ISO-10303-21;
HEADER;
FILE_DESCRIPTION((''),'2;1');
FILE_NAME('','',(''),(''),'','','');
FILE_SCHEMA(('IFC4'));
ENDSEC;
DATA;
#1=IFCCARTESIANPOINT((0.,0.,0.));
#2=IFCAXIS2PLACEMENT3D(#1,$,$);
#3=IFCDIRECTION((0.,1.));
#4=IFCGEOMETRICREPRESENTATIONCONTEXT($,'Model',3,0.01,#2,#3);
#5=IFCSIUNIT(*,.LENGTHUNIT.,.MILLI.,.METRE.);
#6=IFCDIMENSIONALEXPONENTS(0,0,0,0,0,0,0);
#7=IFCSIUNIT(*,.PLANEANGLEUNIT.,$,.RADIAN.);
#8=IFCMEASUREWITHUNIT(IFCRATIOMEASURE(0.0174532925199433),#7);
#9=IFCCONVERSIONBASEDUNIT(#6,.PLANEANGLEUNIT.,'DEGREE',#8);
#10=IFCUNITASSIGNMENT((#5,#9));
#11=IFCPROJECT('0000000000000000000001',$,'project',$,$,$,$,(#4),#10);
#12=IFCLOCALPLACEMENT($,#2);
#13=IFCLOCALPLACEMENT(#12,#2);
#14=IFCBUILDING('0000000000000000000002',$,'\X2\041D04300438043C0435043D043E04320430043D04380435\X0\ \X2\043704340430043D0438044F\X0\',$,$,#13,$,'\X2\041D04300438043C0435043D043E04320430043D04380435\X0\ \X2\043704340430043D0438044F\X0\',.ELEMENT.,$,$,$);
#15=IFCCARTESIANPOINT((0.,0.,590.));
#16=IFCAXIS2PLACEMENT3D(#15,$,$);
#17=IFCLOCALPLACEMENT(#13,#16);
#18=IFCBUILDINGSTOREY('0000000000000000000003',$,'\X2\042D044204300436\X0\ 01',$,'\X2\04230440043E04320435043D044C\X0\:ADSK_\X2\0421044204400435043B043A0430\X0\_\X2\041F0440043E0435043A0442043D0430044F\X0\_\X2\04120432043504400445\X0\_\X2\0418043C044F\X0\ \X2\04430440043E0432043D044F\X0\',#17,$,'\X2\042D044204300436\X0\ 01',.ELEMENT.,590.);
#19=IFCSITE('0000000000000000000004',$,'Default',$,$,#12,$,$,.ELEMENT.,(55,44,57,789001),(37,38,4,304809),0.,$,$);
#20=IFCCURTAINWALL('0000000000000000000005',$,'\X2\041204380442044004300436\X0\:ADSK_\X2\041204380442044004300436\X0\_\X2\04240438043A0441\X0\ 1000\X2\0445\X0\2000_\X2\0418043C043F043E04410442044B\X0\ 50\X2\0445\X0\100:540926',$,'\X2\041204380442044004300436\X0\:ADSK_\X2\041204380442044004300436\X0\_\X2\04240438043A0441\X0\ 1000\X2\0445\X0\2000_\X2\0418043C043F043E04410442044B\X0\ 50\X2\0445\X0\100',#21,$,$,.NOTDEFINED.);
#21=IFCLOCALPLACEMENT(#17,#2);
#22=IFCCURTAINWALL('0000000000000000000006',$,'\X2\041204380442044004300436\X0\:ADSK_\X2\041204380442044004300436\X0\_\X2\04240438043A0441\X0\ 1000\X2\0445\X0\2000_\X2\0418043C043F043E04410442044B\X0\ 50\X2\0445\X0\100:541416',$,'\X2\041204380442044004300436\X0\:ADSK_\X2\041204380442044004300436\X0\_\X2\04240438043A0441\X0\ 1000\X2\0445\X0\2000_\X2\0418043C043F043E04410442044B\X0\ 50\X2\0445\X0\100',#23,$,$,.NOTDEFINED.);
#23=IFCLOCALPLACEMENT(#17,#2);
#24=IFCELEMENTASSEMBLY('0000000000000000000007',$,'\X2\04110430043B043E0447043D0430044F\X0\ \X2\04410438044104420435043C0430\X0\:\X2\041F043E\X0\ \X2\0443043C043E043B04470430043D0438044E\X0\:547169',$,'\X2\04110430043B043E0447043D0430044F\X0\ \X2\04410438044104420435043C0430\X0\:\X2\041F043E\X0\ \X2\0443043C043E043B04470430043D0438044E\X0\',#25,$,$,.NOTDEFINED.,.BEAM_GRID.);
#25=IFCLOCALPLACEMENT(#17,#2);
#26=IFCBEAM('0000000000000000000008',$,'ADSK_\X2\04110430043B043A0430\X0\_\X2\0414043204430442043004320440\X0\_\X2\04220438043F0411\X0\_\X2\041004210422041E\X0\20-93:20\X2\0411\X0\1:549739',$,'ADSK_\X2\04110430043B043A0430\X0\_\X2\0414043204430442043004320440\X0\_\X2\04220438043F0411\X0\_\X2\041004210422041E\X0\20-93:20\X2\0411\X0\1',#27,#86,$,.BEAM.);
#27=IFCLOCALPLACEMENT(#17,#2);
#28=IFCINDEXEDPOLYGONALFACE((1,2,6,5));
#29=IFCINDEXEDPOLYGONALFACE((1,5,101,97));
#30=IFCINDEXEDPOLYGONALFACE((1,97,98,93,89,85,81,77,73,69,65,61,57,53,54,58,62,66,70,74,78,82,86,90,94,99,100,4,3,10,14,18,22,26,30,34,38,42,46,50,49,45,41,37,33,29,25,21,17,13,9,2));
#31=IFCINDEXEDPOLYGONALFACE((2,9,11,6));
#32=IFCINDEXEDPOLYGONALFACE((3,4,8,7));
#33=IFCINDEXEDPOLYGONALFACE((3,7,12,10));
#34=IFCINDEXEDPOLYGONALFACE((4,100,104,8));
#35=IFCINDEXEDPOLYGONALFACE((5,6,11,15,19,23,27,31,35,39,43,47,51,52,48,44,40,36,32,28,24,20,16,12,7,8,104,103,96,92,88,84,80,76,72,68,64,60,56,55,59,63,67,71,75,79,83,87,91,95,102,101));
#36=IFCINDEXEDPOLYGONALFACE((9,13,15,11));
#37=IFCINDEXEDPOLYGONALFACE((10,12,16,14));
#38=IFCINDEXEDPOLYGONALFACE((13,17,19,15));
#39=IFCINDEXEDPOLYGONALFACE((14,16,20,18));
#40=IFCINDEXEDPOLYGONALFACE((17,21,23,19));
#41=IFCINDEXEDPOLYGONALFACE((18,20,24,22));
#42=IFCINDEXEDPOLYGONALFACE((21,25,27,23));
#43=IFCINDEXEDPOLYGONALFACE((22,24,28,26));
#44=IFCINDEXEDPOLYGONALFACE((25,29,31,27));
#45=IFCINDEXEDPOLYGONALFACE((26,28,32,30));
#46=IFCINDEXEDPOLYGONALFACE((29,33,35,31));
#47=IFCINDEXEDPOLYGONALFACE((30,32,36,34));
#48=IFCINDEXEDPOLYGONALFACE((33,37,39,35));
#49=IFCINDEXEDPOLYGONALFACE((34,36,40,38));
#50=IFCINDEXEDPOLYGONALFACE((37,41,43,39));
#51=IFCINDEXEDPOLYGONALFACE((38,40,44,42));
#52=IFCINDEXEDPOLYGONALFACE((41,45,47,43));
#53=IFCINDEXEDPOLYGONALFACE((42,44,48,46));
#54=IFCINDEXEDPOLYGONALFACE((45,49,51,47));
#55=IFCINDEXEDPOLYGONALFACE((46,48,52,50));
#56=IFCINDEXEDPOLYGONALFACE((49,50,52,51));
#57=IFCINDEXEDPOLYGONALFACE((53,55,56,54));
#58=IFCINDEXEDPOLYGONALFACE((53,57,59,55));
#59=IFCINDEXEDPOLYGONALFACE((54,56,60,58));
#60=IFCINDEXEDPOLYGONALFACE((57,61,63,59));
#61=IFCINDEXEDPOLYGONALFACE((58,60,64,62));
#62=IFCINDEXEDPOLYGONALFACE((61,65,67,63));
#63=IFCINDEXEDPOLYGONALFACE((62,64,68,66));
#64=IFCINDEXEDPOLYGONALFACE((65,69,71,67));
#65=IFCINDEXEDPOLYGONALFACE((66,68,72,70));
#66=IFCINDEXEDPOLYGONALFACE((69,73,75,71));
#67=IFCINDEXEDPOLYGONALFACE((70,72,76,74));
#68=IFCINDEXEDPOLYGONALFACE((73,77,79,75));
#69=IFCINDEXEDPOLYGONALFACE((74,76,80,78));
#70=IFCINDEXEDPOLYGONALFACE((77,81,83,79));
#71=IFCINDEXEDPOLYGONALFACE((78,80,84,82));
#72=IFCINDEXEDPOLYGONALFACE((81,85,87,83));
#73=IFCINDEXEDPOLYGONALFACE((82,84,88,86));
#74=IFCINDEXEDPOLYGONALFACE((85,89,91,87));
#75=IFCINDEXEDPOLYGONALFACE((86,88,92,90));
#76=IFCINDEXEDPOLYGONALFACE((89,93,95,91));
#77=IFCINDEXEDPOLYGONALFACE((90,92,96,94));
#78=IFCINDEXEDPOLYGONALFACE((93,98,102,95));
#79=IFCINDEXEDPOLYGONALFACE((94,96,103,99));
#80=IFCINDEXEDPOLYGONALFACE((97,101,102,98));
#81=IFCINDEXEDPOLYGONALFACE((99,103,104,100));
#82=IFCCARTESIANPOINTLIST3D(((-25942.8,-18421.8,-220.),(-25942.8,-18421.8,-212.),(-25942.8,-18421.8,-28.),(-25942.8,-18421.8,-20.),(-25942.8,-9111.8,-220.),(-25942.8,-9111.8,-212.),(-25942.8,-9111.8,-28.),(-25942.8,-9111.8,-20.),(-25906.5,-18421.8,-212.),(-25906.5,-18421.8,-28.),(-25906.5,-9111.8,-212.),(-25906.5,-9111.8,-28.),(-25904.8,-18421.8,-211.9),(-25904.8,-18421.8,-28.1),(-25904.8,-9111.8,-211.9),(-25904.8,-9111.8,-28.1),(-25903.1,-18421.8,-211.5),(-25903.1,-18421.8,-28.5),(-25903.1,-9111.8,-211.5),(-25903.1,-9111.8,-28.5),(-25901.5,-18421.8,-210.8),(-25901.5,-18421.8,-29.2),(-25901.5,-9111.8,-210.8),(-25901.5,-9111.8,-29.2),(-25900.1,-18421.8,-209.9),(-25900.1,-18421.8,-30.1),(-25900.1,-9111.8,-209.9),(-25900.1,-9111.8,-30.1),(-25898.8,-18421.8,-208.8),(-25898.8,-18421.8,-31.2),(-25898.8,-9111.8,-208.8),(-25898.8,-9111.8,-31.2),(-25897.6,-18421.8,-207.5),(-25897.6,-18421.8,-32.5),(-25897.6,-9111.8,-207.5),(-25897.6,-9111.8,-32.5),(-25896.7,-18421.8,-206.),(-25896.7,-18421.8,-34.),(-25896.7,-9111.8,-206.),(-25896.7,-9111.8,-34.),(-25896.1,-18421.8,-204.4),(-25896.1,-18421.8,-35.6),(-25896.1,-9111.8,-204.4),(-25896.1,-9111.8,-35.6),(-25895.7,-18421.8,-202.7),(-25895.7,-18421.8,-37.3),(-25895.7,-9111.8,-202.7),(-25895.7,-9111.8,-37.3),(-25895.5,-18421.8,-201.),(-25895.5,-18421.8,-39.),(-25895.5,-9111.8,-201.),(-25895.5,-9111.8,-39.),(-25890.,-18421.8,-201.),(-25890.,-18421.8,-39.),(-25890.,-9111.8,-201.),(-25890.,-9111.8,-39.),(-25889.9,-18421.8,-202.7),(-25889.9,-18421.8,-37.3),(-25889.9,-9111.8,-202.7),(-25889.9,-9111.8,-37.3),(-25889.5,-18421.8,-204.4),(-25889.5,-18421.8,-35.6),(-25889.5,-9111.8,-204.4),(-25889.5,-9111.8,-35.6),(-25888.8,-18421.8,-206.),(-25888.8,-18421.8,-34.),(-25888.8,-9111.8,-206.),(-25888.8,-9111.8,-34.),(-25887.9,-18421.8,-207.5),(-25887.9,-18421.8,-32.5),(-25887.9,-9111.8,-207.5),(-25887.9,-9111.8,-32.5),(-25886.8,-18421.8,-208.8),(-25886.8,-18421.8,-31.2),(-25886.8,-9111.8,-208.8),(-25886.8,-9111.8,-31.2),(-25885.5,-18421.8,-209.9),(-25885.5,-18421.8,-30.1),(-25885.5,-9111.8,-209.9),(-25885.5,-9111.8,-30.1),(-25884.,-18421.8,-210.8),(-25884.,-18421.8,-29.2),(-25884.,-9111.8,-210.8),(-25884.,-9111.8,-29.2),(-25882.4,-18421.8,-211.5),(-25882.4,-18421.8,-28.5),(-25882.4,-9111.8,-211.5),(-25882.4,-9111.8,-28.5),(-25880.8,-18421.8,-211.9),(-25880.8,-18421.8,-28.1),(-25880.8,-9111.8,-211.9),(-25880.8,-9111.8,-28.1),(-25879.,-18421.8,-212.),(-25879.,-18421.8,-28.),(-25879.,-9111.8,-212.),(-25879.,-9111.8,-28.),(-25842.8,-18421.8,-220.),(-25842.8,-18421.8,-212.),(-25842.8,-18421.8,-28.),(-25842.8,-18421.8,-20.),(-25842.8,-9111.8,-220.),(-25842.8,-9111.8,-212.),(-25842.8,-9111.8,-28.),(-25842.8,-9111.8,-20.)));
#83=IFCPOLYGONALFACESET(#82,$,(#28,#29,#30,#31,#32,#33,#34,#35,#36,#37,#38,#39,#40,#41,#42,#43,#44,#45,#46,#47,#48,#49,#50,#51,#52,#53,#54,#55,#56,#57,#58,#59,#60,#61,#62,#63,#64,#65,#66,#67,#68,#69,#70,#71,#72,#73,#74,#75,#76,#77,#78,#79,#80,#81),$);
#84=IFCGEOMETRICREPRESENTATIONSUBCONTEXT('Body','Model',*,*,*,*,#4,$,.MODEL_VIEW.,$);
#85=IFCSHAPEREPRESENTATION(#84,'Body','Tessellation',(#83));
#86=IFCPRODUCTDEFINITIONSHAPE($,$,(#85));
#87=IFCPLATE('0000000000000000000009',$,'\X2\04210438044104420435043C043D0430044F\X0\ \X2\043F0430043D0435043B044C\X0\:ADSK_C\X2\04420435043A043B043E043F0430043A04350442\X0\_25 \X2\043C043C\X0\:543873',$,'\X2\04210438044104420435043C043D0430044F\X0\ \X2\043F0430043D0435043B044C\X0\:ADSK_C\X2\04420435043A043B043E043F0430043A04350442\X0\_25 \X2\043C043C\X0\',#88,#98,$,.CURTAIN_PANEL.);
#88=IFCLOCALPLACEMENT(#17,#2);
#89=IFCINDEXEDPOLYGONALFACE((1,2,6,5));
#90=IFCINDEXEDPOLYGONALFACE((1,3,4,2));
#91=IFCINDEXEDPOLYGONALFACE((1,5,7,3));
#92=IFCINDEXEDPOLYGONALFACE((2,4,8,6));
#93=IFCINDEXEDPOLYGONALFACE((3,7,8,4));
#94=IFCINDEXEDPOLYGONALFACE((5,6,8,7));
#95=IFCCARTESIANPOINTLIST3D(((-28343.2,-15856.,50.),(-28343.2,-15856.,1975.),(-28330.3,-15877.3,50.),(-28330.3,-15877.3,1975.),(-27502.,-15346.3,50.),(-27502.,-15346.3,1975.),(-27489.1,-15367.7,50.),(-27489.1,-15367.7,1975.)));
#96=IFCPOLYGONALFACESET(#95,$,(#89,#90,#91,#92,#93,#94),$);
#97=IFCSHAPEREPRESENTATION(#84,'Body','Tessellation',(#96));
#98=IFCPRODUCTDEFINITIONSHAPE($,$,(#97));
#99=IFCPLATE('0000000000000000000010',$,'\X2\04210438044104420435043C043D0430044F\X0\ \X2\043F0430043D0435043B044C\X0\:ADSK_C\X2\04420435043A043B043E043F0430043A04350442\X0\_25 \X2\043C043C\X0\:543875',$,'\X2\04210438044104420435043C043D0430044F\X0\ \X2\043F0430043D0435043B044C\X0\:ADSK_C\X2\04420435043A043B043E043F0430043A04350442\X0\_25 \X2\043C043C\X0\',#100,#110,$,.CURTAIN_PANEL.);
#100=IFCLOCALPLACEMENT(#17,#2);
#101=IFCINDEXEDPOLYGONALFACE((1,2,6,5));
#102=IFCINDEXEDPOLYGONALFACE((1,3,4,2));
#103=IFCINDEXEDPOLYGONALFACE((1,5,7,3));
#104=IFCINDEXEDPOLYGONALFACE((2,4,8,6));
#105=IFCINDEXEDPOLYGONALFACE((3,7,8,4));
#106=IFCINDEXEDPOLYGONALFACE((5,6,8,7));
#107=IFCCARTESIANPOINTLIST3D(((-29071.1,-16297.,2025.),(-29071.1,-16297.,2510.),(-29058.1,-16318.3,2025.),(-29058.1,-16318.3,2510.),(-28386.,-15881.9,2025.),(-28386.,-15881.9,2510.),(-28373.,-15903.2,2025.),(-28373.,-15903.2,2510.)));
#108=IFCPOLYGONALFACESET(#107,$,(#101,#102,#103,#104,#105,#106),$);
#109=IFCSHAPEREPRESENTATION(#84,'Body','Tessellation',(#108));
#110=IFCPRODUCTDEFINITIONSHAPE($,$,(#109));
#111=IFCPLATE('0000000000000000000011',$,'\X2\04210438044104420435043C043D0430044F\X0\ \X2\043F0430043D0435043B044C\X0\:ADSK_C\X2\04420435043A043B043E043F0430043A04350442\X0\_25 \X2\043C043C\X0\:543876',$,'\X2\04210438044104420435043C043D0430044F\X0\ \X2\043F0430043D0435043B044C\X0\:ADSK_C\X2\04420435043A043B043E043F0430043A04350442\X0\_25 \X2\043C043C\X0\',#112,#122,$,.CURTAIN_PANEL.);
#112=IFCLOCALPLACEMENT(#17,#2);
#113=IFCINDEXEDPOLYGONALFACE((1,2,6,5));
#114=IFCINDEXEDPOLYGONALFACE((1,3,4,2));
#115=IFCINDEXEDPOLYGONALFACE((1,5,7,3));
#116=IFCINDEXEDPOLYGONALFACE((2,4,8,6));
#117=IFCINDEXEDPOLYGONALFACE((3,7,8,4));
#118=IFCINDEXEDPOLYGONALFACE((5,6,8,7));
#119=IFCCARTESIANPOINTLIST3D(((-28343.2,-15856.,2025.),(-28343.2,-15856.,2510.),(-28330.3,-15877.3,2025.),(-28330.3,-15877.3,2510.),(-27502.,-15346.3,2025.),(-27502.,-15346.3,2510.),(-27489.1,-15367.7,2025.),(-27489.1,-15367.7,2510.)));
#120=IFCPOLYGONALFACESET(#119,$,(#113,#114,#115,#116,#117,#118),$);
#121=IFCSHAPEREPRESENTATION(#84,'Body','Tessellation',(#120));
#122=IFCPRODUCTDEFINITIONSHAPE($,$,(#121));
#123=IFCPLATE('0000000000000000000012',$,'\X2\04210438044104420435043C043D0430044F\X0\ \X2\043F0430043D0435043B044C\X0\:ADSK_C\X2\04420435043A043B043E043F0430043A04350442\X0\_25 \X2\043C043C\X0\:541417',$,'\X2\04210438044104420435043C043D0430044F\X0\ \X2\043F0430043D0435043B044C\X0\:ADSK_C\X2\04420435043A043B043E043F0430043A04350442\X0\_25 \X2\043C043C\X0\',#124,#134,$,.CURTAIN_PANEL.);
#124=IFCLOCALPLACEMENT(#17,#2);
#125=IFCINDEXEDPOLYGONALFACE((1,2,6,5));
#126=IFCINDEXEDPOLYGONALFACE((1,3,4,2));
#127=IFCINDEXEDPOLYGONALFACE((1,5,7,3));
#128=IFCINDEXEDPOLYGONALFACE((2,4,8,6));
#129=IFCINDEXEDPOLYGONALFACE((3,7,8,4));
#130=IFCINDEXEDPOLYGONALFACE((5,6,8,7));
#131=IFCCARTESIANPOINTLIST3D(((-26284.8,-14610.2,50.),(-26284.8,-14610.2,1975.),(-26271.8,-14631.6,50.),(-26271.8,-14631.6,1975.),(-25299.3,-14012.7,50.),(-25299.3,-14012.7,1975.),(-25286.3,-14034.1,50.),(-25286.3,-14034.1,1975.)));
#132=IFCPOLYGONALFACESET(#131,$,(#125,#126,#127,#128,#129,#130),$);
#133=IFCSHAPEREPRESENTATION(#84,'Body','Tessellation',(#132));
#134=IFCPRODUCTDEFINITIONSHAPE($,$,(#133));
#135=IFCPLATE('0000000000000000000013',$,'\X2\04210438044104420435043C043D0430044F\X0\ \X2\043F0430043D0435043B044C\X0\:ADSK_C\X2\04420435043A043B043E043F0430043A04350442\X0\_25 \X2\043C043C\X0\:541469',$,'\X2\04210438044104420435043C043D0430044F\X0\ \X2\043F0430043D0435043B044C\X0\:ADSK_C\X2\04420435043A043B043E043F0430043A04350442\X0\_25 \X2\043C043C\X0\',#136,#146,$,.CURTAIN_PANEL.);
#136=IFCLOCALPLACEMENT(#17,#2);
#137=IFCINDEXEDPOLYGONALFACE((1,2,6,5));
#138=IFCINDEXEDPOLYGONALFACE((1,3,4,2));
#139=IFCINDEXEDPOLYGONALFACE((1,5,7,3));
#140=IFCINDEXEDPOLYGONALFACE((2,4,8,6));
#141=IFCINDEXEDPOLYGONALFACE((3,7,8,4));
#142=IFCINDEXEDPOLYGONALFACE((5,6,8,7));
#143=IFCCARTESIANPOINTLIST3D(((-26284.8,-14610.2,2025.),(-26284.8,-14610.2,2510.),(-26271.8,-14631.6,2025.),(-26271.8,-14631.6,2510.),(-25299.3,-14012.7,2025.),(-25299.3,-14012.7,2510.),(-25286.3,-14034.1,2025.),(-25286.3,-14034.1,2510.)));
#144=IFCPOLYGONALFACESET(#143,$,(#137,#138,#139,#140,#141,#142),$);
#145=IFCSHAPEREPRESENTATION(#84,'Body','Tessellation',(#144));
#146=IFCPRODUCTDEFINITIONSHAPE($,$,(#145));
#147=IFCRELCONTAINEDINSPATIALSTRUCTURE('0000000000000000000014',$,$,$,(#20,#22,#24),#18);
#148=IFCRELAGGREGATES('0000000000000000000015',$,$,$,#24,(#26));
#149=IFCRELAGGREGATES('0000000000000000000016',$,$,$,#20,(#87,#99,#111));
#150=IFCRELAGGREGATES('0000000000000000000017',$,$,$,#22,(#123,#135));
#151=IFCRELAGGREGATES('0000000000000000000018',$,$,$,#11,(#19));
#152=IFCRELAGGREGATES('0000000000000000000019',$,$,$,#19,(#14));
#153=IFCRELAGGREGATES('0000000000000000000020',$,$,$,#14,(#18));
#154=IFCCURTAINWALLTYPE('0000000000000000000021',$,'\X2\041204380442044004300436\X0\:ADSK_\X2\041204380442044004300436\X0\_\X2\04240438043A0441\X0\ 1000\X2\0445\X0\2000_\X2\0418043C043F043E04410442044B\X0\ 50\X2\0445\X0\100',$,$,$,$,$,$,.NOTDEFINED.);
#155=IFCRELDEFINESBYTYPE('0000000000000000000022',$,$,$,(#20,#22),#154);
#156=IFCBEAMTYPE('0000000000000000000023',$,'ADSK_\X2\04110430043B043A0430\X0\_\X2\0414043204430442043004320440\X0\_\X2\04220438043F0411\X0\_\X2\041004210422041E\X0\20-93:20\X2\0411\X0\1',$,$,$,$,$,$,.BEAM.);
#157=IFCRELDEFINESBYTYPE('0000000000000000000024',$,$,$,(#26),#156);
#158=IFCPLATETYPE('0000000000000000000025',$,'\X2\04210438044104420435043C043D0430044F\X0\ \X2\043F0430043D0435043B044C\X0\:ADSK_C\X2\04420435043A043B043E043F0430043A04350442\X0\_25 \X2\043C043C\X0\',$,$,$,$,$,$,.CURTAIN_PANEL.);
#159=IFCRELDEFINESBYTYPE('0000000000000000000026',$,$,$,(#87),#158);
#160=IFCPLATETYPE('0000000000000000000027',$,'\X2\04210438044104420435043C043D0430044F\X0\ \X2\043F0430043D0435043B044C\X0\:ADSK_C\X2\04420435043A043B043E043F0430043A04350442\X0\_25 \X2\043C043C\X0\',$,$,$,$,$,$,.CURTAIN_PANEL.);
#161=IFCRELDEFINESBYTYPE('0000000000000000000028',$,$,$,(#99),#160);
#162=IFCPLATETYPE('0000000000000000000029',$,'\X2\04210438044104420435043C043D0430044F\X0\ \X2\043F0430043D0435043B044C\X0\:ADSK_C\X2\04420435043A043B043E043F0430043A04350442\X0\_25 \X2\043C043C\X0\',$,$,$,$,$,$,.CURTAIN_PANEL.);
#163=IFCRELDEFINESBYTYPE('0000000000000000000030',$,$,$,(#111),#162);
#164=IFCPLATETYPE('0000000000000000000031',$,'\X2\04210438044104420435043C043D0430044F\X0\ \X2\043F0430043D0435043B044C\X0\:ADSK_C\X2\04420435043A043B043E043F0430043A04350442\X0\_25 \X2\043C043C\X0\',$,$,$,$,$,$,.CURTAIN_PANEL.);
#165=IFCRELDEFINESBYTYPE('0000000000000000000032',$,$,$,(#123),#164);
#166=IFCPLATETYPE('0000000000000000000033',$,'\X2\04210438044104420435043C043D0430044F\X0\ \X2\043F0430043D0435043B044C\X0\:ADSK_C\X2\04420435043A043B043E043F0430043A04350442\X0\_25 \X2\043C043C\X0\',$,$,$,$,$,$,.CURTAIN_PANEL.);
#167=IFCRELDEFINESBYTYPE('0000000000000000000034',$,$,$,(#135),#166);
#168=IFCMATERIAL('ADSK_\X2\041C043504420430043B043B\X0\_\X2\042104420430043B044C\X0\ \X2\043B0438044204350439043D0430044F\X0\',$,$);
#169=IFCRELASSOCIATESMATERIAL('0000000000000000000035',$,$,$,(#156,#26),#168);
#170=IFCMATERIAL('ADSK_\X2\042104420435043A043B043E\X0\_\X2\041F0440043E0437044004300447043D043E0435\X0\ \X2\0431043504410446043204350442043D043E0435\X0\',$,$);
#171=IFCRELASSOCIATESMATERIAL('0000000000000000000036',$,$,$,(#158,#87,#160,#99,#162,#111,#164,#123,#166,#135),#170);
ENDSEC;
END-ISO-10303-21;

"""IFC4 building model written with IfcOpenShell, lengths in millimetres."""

from ifc_helpers import new_model, entity, si_unit, converted_unit, direction, frame, origin, place, context, subcontext, project, spatial, indexed_curve, outline, extrude, source, transform, mapped, material, type_object, type_shapes, element, aggregate, save


model = new_model("IFC4")

# Units and contexts
model_context = context("Model", 3, precision=0.01, world=origin(), true_north=direction((0.0, 1.0)))
body_context = subcontext(model_context, "Body", "Model", "MODEL_VIEW")
ifc_project = project(units=[si_unit("LENGTHUNIT", "METRE", prefix="MILLI"), converted_unit("PLANEANGLEUNIT", "DEGREE", entity("IfcRatioMeasure", 0.0174532925199433), si_unit("PLANEANGLEUNIT", "RADIAN"), dimensions=[0, 0, 0, 0, 0, 0, 0])], contexts=[model_context])

# Site, building, storey
site_placement = place(None, origin())
site = spatial("IfcSite", under=ifc_project, at=site_placement, Name="Default", CompositionType="ELEMENT", RefLatitude=(55, 44, 57, 789001), RefLongitude=(37, 38, 4, 304809), RefElevation=0.0)
building_placement = place(site_placement, origin())
building = spatial("IfcBuilding", under=site, at=building_placement, Name="Наименование здания", LongName="Наименование здания", CompositionType="ELEMENT")
storey_placement = place(building_placement, frame((0.0, 0.0, 590.0)))
storey = spatial("IfcBuildingStorey", under=building, at=storey_placement, Name="Этаж 01", ObjectType="Уровень:ADSK_Стрелка_Проектная_Вверх_Имя уровня", LongName="Этаж 01", CompositionType="ELEMENT", Elevation=590.0)

# Curtain walls
curtain_wall_type = type_object("IfcCurtainWallType", Name="Витраж:ADSK_Витраж_Фикс 1000х2000_Импосты 50х100", PredefinedType="NOTDEFINED")
curtain_wall_1_placement = place(storey_placement, frame((0.0, 0.0, -590.0)))
curtain_wall_1 = element("IfcCurtainWall", 1, at=curtain_wall_1_placement, inside=storey, type_object=curtain_wall_type, Name="Витраж:ADSK_Витраж_Фикс 1000х2000_Импосты 50х100:540926", ObjectType="Витраж:ADSK_Витраж_Фикс 1000х2000_Импосты 50х100", PredefinedType="NOTDEFINED")
curtain_wall_2_placement = place(storey_placement, frame((0.0, 0.0, -590.0)))
curtain_wall_2 = element("IfcCurtainWall", 2, at=curtain_wall_2_placement, inside=storey, type_object=curtain_wall_type, Name="Витраж:ADSK_Витраж_Фикс 1000х2000_Импосты 50х100:541416", ObjectType="Витраж:ADSK_Витраж_Фикс 1000х2000_Импосты 50х100", PredefinedType="NOTDEFINED")

# Element assembly, beam
assembly_placement = place(storey_placement, origin())
assembly = element("IfcElementAssembly", 3, at=assembly_placement, inside=storey, Name="Балочная система:По умолчанию:547169", ObjectType="Балочная система:По умолчанию", AssemblyPlace="NOTDEFINED", PredefinedType="BEAM_GRID")
ifc_material_1 = material(Name="ADSK_Металл_Сталь литейная")
beam_type_1 = type_object("IfcBeamType", Name="ADSK_Балка_Двутавр_ТипБ_АСТО20-93:20Б1", PredefinedType="BEAM", material=ifc_material_1)
shared_shape_1 = source(origin(), body_context, "Body", "SweptSolid", [
    extrude(outline(indexed_curve([(-100.0, -50.0), (-92.0, -50.0), (-92.0, -13.8), (-91.9, -12.0), (-91.5, -10.4), (-90.8, -8.8), (-89.9, -7.3), (-88.8, -6.0), (-87.5, -4.9), (-86.0, -3.9), (-84.4, -3.3), (-82.7, -2.9), (-81.0, -2.8), (81.0, -2.8), (82.7, -2.9), (84.4, -3.3), (86.0, -3.9), (87.5, -4.9), (88.8, -6.0), (89.9, -7.3), (90.8, -8.8), (91.5, -10.4), (91.9, -12.0), (92.0, -13.7), (92.0, -50.0), (100.0, -50.0), (100.0, 50.0), (92.0, 50.0), (92.0, 13.8), (91.9, 12.0), (91.5, 10.4), (90.8, 8.8), (89.9, 7.3), (88.8, 6.0), (87.5, 4.9), (86.0, 3.9), (84.4, 3.3), (82.7, 2.9), (81.0, 2.8), (-81.0, 2.8), (-82.7, 2.9), (-84.4, 3.3), (-86.0, 3.9), (-87.5, 4.9), (-88.8, 6.0), (-89.9, 7.3), (-90.8, 8.8), (-91.5, 10.4), (-91.9, 12.0), (-92.0, 13.8), (-92.0, 50.0), (-100.0, 50.0), (-100.0, -50.0)], self_intersect=False)), frame((-4655.0, 0.0, -100.0), z_axis=(1.0, 0.0, 0.0), x_axis=(0.0, 0.0, -1.0)), (0.0, 0.0, 1.0), 9310.0),
])
type_shapes(beam_type_1, [shared_shape_1])
beam_1_placement = place(assembly_placement, frame((-25892.8, -13766.8, -20.0), z_axis=(0.0, 0.0, 1.0), x_axis=(0.0, 1.0, 0.0)))
beam_1 = element("IfcBeam", 4, at=beam_1_placement, type_object=beam_type_1, material=ifc_material_1, Name="ADSK_Балка_Двутавр_ТипБ_АСТО20-93:20Б1:549739", ObjectType="ADSK_Балка_Двутавр_ТипБ_АСТО20-93:20Б1", PredefinedType="BEAM", context=body_context, shape_type="MappedRepresentation", body=[
    mapped(shared_shape_1, transform((0.0, 0.0, 0.0), scale=1.0)),
])
aggregate(assembly, [beam_1])

# Plates
ifc_material_2 = material(Name="ADSK_Стекло_Прозрачное бесцветное")
plate_type_1 = type_object("IfcPlateType", Name="Системная панель:ADSK_Cтеклопакет_25 мм", PredefinedType="CURTAIN_PANEL", material=ifc_material_2)
shared_shape_2 = source(origin(), body_context, "Body", "SweptSolid", [
    extrude(outline(indexed_curve([(-12.5, -491.8), (12.5, -491.8), (12.5, 491.8), (-12.5, 491.8), (-12.5, -491.8)], self_intersect=False)), frame((0.0, 0.0, 0.0), z_axis=(0.0, 0.0, 1.0), x_axis=(0.0, 1.0, 0.0)), (0.0, 0.0, 1.0), 1925.0),
])
type_shapes(plate_type_1, [shared_shape_2])
plate_1_placement = place(curtain_wall_1_placement, frame((-27916.1, -15611.8, 640.0), z_axis=(0.0, 0.0, 1.0), x_axis=(0.855267, 0.518188, 0.0)))
plate_1 = element("IfcPlate", 5, at=plate_1_placement, type_object=plate_type_1, material=ifc_material_2, Name="Системная панель:ADSK_Cтеклопакет_25 мм:543873", ObjectType="Системная панель:ADSK_Cтеклопакет_25 мм", PredefinedType="CURTAIN_PANEL", context=body_context, shape_type="MappedRepresentation", body=[
    mapped(shared_shape_2, transform((0.0, 0.0, 0.0), scale=1.0)),
])
plate_type_2 = type_object("IfcPlateType", Name="Системная панель:ADSK_Cтеклопакет_25 мм", PredefinedType="CURTAIN_PANEL", material=ifc_material_2)
shared_shape_3 = source(origin(), body_context, "Body", "SweptSolid", [
    extrude(outline(indexed_curve([(-12.5, -400.5), (12.5, -400.5), (12.5, 400.5), (-12.5, 400.5), (-12.5, -400.5)], self_intersect=False)), frame((0.0, 0.0, 0.0), z_axis=(0.0, 0.0, 1.0), x_axis=(0.0, 1.0, 0.0)), (0.0, 0.0, 1.0), 485.0),
])
type_shapes(plate_type_2, [shared_shape_3])
plate_2_placement = place(curtain_wall_1_placement, frame((-28722.0, -16100.1, 2615.0), z_axis=(0.0, 0.0, 1.0), x_axis=(0.855267, 0.518188, 0.0)))
plate_2 = element("IfcPlate", 6, at=plate_2_placement, type_object=plate_type_2, material=ifc_material_2, Name="Системная панель:ADSK_Cтеклопакет_25 мм:543875", ObjectType="Системная панель:ADSK_Cтеклопакет_25 мм", PredefinedType="CURTAIN_PANEL", context=body_context, shape_type="MappedRepresentation", body=[
    mapped(shared_shape_3, transform((0.0, 0.0, 0.0), scale=1.0)),
])
plate_type_3 = type_object("IfcPlateType", Name="Системная панель:ADSK_Cтеклопакет_25 мм", PredefinedType="CURTAIN_PANEL", material=ifc_material_2)
shared_shape_4 = source(origin(), body_context, "Body", "SweptSolid", [
    extrude(outline(indexed_curve([(-12.5, -491.8), (12.5, -491.8), (12.5, 491.8), (-12.5, 491.8), (-12.5, -491.8)], self_intersect=False)), frame((0.0, 0.0, 0.0), z_axis=(0.0, 0.0, 1.0), x_axis=(0.0, 1.0, 0.0)), (0.0, 0.0, 1.0), 485.0),
])
type_shapes(plate_type_3, [shared_shape_4])
plate_3_placement = place(curtain_wall_1_placement, frame((-27916.1, -15611.8, 2615.0), z_axis=(0.0, 0.0, 1.0), x_axis=(0.855267, 0.518188, 0.0)))
plate_3 = element("IfcPlate", 7, at=plate_3_placement, type_object=plate_type_3, material=ifc_material_2, Name="Системная панель:ADSK_Cтеклопакет_25 мм:543876", ObjectType="Системная панель:ADSK_Cтеклопакет_25 мм", PredefinedType="CURTAIN_PANEL", context=body_context, shape_type="MappedRepresentation", body=[
    mapped(shared_shape_4, transform((0.0, 0.0, 0.0), scale=1.0)),
])
aggregate(curtain_wall_1, [plate_1, plate_2, plate_3])
plate_type_4 = type_object("IfcPlateType", Name="Системная панель:ADSK_Cтеклопакет_25 мм", PredefinedType="CURTAIN_PANEL", material=ifc_material_2)
shared_shape_5 = source(origin(), body_context, "Body", "SweptSolid", [
    extrude(outline(indexed_curve([(-12.5, -576.3), (12.5, -576.3), (12.5, 576.3), (-12.5, 576.3), (-12.5, -576.3)], self_intersect=False)), frame((0.0, 0.0, 0.0), z_axis=(0.0, 0.0, 1.0), x_axis=(0.0, 1.0, 0.0)), (0.0, 0.0, 1.0), 1925.0),
])
type_shapes(plate_type_4, [shared_shape_5])
plate_4_placement = place(curtain_wall_2_placement, frame((-25785.5, -14322.2, 640.0), z_axis=(0.0, 0.0, 1.0), x_axis=(0.855102, 0.51846, 0.0)))
plate_4 = element("IfcPlate", 8, at=plate_4_placement, type_object=plate_type_4, material=ifc_material_2, Name="Системная панель:ADSK_Cтеклопакет_25 мм:541417", ObjectType="Системная панель:ADSK_Cтеклопакет_25 мм", PredefinedType="CURTAIN_PANEL", context=body_context, shape_type="MappedRepresentation", body=[
    mapped(shared_shape_5, transform((0.0, 0.0, 0.0), scale=1.0)),
])
plate_type_5 = type_object("IfcPlateType", Name="Системная панель:ADSK_Cтеклопакет_25 мм", PredefinedType="CURTAIN_PANEL", material=ifc_material_2)
shared_shape_6 = source(origin(), body_context, "Body", "SweptSolid", [
    extrude(outline(indexed_curve([(-12.5, -576.3), (12.5, -576.3), (12.5, 576.3), (-12.5, 576.3), (-12.5, -576.3)], self_intersect=False)), frame((0.0, 0.0, 0.0), z_axis=(0.0, 0.0, 1.0), x_axis=(0.0, 1.0, 0.0)), (0.0, 0.0, 1.0), 485.0),
])
type_shapes(plate_type_5, [shared_shape_6])
plate_5_placement = place(curtain_wall_2_placement, frame((-25785.5, -14322.2, 2615.0), z_axis=(0.0, 0.0, 1.0), x_axis=(0.855102, 0.51846, 0.0)))
plate_5 = element("IfcPlate", 9, at=plate_5_placement, type_object=plate_type_5, material=ifc_material_2, Name="Системная панель:ADSK_Cтеклопакет_25 мм:541469", ObjectType="Системная панель:ADSK_Cтеклопакет_25 мм", PredefinedType="CURTAIN_PANEL", context=body_context, shape_type="MappedRepresentation", body=[
    mapped(shared_shape_6, transform((0.0, 0.0, 0.0), scale=1.0)),
])
aggregate(curtain_wall_2, [plate_4, plate_5])

save(model, "model.ifc")
